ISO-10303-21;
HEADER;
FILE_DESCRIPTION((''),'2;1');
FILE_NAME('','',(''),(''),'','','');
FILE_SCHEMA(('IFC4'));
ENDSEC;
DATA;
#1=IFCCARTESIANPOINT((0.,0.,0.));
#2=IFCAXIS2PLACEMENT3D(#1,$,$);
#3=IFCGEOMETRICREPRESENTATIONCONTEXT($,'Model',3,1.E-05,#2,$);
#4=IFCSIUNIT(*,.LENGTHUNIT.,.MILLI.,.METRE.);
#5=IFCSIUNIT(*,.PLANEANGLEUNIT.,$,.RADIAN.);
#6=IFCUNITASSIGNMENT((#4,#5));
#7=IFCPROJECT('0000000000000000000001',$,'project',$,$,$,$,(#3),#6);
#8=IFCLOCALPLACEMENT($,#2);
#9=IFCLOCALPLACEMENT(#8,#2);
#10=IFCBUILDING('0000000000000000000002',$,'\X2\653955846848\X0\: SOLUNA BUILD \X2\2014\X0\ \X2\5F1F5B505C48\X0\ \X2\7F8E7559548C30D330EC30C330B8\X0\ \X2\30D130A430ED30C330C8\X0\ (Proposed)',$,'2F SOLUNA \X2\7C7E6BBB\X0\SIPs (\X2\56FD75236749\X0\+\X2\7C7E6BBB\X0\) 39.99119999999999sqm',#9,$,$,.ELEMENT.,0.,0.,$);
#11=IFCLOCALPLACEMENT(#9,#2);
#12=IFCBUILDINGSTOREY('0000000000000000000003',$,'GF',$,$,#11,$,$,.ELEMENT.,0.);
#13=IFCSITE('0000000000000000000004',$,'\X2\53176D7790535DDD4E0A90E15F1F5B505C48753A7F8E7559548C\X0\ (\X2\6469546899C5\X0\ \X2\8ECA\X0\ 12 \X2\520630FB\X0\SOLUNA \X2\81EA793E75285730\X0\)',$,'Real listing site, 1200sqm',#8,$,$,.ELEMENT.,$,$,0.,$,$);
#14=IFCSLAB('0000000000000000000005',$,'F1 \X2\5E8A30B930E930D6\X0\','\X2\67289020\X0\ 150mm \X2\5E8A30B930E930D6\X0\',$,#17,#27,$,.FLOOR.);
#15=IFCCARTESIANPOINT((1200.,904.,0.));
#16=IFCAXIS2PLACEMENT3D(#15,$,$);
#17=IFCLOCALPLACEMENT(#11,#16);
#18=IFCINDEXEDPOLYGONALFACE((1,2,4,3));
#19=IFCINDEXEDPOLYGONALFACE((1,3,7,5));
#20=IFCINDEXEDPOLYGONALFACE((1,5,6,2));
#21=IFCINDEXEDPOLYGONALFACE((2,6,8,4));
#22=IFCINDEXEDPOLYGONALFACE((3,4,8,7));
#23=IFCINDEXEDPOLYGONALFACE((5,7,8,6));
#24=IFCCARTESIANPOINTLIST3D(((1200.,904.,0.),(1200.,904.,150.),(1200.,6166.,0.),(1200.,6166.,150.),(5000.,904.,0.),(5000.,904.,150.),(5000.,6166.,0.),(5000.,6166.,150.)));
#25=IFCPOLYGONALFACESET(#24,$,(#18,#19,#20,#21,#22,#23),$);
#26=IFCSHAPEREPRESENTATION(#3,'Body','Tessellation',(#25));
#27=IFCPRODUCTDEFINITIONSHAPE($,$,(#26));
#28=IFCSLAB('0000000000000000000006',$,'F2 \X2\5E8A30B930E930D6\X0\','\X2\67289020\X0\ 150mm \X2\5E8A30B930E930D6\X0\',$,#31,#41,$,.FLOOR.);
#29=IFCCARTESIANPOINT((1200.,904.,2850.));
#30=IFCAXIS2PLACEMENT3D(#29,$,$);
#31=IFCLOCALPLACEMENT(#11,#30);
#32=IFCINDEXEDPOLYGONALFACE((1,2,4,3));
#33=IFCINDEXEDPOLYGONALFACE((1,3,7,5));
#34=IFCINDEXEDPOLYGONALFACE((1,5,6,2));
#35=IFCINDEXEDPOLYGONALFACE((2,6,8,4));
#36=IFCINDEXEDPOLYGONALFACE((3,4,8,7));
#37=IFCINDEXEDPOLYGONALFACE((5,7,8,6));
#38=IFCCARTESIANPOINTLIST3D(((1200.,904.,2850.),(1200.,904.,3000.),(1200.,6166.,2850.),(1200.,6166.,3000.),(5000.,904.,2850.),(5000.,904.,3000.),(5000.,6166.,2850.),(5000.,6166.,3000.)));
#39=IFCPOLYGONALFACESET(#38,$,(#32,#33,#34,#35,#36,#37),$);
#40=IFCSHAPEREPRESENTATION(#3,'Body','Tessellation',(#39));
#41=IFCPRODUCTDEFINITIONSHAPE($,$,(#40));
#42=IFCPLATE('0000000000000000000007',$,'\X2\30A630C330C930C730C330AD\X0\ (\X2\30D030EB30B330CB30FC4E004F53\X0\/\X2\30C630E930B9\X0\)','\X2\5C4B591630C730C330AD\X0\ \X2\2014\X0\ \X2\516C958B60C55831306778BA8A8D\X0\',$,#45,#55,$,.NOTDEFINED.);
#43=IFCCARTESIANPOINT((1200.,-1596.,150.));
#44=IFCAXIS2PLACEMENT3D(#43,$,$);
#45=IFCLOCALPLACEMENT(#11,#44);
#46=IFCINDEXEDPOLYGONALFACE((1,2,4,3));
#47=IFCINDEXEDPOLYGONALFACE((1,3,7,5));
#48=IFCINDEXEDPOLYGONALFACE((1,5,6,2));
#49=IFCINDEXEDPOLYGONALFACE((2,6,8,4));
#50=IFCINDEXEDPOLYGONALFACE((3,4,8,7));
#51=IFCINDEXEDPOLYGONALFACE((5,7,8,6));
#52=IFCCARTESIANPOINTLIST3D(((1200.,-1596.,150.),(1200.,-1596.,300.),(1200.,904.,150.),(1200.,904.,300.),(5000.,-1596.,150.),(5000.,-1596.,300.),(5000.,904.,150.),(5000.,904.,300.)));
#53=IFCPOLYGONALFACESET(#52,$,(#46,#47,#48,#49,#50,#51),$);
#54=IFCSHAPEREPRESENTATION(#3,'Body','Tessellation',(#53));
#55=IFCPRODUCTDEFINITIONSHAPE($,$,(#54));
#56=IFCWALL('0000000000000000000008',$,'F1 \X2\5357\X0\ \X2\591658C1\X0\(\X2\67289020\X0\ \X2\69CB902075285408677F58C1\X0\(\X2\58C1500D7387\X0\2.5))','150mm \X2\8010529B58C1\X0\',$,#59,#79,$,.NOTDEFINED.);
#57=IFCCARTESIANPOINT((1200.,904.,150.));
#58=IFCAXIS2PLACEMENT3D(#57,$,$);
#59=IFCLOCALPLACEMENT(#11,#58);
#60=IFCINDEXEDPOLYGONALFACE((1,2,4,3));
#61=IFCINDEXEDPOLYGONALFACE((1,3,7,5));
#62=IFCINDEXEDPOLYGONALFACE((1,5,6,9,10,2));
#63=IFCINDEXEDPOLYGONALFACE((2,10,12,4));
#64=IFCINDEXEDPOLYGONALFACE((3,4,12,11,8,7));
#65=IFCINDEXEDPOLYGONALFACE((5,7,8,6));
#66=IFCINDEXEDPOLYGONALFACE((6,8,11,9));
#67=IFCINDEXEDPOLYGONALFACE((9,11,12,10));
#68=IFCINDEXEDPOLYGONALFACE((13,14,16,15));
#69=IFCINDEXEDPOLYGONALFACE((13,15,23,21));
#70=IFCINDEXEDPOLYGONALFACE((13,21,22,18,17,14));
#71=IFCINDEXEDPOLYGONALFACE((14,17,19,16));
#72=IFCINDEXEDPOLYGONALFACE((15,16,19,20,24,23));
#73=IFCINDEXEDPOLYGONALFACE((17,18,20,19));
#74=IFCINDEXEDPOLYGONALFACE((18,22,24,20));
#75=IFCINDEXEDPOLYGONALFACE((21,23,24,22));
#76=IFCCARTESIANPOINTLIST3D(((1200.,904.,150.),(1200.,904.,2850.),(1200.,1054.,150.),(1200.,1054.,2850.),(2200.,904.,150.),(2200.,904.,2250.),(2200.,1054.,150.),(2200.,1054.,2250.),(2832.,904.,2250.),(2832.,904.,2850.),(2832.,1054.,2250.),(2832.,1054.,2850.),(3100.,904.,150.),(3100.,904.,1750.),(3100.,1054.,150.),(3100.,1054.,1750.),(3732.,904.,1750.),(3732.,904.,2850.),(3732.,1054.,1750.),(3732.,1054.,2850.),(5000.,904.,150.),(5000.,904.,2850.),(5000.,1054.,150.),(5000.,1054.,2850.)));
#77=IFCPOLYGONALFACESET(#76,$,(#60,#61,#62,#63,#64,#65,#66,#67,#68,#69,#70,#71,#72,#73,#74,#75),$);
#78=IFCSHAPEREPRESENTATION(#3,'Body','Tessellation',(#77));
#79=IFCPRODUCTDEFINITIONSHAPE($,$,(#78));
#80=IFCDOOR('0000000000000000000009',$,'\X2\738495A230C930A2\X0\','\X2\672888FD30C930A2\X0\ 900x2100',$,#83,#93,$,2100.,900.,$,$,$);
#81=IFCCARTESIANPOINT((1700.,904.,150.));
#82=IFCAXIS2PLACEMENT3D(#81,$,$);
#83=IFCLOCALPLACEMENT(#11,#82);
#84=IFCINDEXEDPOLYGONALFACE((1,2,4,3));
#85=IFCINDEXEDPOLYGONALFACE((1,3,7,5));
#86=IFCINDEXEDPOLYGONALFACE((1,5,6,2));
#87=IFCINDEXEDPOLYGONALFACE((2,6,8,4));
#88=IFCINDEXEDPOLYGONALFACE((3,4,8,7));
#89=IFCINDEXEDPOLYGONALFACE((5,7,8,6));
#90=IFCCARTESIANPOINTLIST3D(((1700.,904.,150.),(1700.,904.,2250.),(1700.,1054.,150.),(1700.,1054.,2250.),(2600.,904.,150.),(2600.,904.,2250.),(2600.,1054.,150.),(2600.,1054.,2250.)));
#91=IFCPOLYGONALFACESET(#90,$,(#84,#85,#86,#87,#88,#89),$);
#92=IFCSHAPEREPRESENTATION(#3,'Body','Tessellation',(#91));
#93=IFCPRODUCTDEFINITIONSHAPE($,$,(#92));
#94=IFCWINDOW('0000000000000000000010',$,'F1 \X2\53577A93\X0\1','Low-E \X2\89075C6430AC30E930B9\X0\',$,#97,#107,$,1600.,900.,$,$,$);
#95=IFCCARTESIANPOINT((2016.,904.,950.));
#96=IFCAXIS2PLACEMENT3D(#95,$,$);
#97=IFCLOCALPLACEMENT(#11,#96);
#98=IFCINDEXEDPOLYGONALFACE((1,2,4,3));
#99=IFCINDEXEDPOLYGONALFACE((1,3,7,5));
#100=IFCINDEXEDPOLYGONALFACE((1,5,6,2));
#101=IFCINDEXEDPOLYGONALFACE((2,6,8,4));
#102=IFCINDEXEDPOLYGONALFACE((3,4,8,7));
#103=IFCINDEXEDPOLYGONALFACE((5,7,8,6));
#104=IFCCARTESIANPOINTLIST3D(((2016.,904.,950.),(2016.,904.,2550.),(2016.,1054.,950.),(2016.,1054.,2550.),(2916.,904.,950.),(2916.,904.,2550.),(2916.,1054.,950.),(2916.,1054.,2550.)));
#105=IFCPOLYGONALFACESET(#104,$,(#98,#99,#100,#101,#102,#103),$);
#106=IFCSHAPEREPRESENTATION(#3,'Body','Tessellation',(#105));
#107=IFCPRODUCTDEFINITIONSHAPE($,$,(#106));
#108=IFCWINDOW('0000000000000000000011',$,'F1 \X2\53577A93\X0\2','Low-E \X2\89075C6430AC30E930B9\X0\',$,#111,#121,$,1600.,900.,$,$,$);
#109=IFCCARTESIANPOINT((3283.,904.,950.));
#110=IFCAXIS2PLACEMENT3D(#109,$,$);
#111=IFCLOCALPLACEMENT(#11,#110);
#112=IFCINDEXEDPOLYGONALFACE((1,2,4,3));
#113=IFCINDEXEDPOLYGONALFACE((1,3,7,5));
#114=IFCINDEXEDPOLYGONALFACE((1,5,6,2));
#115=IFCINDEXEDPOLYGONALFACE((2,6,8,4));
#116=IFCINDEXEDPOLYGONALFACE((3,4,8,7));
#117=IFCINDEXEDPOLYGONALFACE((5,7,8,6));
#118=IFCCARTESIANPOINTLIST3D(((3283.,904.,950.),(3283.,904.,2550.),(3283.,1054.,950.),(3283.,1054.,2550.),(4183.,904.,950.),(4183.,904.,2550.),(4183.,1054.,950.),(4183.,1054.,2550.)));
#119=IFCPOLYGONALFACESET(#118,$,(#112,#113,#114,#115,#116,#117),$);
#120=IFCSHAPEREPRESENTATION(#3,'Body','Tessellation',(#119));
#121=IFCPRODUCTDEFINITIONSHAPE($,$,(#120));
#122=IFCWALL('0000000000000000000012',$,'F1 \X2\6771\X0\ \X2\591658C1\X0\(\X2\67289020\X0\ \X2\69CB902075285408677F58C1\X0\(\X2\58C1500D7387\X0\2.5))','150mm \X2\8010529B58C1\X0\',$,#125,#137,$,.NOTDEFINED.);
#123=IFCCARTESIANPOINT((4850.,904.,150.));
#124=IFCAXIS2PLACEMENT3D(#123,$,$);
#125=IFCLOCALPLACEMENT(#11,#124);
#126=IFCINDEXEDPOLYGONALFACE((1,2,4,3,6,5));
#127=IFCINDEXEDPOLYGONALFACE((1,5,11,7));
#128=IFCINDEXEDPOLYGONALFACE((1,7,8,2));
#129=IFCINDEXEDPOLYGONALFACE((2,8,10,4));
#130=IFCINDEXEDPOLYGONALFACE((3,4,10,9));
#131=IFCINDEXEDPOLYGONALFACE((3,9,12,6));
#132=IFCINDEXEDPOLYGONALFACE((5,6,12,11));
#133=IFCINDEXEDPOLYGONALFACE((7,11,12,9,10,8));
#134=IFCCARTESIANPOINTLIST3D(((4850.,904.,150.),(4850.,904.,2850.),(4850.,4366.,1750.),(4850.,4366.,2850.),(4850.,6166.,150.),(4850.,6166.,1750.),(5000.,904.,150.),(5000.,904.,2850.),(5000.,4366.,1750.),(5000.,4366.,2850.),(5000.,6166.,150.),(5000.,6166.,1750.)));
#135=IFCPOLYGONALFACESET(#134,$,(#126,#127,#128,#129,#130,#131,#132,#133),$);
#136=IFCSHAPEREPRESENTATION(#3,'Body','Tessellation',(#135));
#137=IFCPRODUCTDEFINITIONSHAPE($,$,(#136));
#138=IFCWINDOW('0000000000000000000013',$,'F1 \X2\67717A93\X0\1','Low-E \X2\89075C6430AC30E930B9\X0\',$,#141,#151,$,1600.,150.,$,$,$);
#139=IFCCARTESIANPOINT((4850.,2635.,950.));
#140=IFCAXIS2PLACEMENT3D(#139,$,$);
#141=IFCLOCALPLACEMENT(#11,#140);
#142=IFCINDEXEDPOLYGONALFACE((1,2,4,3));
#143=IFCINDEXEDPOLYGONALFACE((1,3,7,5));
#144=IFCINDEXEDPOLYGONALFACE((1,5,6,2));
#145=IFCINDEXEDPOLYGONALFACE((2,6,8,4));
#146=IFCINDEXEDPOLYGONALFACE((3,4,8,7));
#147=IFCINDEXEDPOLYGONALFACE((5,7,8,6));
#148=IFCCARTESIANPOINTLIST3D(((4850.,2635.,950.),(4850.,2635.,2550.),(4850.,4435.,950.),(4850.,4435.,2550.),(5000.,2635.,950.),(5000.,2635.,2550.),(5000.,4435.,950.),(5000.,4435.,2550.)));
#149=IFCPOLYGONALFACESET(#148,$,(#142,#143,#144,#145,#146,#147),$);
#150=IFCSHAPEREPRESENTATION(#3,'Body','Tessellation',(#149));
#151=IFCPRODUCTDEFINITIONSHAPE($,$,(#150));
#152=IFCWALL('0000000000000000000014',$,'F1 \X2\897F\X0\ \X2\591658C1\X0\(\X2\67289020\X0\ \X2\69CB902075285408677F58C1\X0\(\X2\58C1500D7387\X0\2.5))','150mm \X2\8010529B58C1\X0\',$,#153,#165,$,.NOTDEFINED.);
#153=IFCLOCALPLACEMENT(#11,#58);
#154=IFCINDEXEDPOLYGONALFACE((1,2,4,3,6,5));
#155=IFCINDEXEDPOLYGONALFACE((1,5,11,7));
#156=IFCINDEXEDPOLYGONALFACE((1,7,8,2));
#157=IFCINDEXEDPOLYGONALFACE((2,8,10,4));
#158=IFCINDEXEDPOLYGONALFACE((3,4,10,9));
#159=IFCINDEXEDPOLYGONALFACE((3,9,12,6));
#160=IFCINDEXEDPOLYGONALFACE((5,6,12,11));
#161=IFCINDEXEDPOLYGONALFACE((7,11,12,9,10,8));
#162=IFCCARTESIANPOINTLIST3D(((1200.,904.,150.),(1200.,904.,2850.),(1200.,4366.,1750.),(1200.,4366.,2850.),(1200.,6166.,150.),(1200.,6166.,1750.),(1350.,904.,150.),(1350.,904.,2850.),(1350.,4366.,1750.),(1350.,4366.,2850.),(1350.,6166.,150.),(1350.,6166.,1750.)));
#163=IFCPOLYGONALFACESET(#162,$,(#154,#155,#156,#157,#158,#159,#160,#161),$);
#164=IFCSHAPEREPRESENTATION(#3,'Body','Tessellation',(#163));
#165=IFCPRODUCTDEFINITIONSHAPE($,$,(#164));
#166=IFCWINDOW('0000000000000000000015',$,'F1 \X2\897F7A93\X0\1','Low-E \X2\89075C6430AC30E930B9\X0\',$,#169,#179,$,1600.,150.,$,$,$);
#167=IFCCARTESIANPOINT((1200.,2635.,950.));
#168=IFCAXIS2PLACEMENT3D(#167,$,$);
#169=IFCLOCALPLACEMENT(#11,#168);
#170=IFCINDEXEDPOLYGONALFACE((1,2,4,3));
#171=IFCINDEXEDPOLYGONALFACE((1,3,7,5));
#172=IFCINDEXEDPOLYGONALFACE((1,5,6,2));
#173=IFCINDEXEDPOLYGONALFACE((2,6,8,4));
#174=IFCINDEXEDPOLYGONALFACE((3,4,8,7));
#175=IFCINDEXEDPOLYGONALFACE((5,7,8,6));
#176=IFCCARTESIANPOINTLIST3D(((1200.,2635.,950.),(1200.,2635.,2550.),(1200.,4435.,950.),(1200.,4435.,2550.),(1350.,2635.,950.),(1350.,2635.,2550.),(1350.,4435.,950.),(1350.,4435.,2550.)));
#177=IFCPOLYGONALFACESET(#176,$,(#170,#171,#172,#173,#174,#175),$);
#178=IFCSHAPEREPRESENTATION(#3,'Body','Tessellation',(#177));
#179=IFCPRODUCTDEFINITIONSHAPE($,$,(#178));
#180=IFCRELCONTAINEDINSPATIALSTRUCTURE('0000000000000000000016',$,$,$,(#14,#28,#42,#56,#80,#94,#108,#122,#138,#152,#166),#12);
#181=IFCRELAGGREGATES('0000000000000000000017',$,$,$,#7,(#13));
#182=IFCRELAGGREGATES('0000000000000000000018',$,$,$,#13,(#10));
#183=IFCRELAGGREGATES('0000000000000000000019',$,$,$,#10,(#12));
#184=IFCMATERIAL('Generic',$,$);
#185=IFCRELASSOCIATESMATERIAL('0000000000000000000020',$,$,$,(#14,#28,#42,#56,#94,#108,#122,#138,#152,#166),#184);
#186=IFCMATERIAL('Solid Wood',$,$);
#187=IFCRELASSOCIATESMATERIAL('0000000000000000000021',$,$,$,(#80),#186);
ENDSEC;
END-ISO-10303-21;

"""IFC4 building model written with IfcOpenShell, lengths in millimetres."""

from ifc_helpers import new_model, si_unit, frame, frame_2d, origin, place, context, project, spatial, rectangle, extrude, material, element, fill, save


model = new_model("IFC4")

# Units and contexts
model_context = context("Model", 3, precision=1e-05, world=origin())
ifc_project = project(units=[si_unit("LENGTHUNIT", "METRE", prefix="MILLI"), si_unit("PLANEANGLEUNIT", "RADIAN")], contexts=[model_context])

# Site, building, storey
site_placement = place(None, origin())
site = spatial("IfcSite", under=ifc_project, at=site_placement, Name="北海道川上郡弟子屈町美留和 (摩周駅 車 12 分・SOLUNA 自社用地)", ObjectType="Real listing site, 1200sqm", CompositionType="ELEMENT", RefElevation=0.0)
building_placement = place(site_placement, origin())
building = spatial("IfcBuilding", under=site, at=building_placement, Name="改善案: SOLUNA BUILD — 弟子屈 美留和ビレッジ パイロット (Proposed)", ObjectType="2F SOLUNA 籾殻SIPs (国産杉+籾殻) 39.99119999999999sqm", CompositionType="ELEMENT", ElevationOfRefHeight=0.0, ElevationOfTerrain=0.0)
storey_placement = place(building_placement, origin())
storey = spatial("IfcBuildingStorey", under=building, at=storey_placement, Name="GF", CompositionType="ELEMENT", Elevation=0.0)

# Slabs
ifc_material_1 = material(Name="Generic")
slab_1_placement = place(storey_placement, frame((1200.0, 904.0, 0.0)))
element("IfcSlab", 1, at=slab_1_placement, inside=storey, material=ifc_material_1, Name="F1 床スラブ", Description="木造 150mm 床スラブ", PredefinedType="FLOOR", context=model_context, shape_type="SweptSolid", body=[
    extrude(rectangle(XDim=3800.0, YDim=5262.0, at=frame_2d((1900.0, 2631.0))), frame((1200.0, 904.0, 0.0)), (0.0, 0.0, 1.0), 150.0),
])
slab_2_placement = place(storey_placement, frame((1200.0, 904.0, 2850.0)))
element("IfcSlab", 2, at=slab_2_placement, inside=storey, material=ifc_material_1, Name="F2 床スラブ", Description="木造 150mm 床スラブ", PredefinedType="FLOOR", context=model_context, shape_type="SweptSolid", body=[
    extrude(rectangle(XDim=3800.0, YDim=5262.0, at=frame_2d((1900.0, 2631.0))), frame((1200.0, 904.0, 2850.0)), (0.0, 0.0, 1.0), 150.0),
])

# Plate
plate_placement = place(storey_placement, frame((1200.0, -1596.0, 150.0)))
element("IfcPlate", 3, at=plate_placement, inside=storey, material=ifc_material_1, Name="ウッドデッキ (バルコニー一体/テラス)", Description="屋外デッキ — 公開情報で確認", PredefinedType="NOTDEFINED", context=model_context, shape_type="SweptSolid", body=[
    extrude(rectangle(XDim=3800.0, YDim=2500.0, at=frame_2d((1900.0, 1250.0))), frame((1200.0, -1596.0, 150.0)), (0.0, 0.0, 1.0), 150.0),
])

# Wall, openings, door, windows
wall_1_placement = place(storey_placement, frame((1200.0, 904.0, 150.0)))
wall_1 = element("IfcWall", 4, at=wall_1_placement, inside=storey, material=ifc_material_1, Name="F1 南 外壁(木造 構造用合板壁(壁倍率2.5))", Description="150mm 耐力壁", PredefinedType="NOTDEFINED", context=model_context, shape_type="SweptSolid", body=[
    extrude(rectangle(XDim=3800.0, YDim=150.0, at=frame_2d((1900.0, 75.0))), frame((1200.0, 904.0, 150.0)), (0.0, 0.0, 1.0), 2700.0),
])
opening_1_placement = place(storey_placement, frame((1700.0, 904.0, 150.0)))
opening_1 = element("IfcOpeningElement", 5, at=opening_1_placement, cuts=wall_1, PredefinedType="NOTDEFINED", context=model_context, shape_type="SweptSolid", body=[
    extrude(rectangle(XDim=900.0, YDim=150.0, at=frame_2d((450.0, 75.0))), frame((1700.0, 904.0, 150.0)), (0.0, 0.0, 1.0), 2100.0),
])
opening_2_placement = place(storey_placement, frame((2016.0, 904.0, 950.0)))
opening_2 = element("IfcOpeningElement", 6, at=opening_2_placement, cuts=wall_1, PredefinedType="NOTDEFINED", context=model_context, shape_type="SweptSolid", body=[
    extrude(rectangle(XDim=900.0, YDim=150.0, at=frame_2d((450.0, 75.0))), frame((2016.0, 904.0, 950.0)), (0.0, 0.0, 1.0), 1600.0),
])
opening_3_placement = place(storey_placement, frame((3283.0, 904.0, 950.0)))
opening_3 = element("IfcOpeningElement", 7, at=opening_3_placement, cuts=wall_1, PredefinedType="NOTDEFINED", context=model_context, shape_type="SweptSolid", body=[
    extrude(rectangle(XDim=900.0, YDim=150.0, at=frame_2d((450.0, 75.0))), frame((3283.0, 904.0, 950.0)), (0.0, 0.0, 1.0), 1600.0),
])
ifc_material_2 = material(Name="Solid Wood")
door_placement = place(storey_placement, frame((1700.0, 904.0, 150.0)))
door = element("IfcDoor", 8, at=door_placement, inside=storey, material=ifc_material_2, Name="玄関ドア", Description="木製ドア 900x2100", OverallHeight=2100.0, OverallWidth=900.0, context=model_context, shape_type="SweptSolid", body=[
    extrude(rectangle(XDim=900.0, YDim=150.0, at=frame_2d((450.0, 75.0))), frame((1700.0, 904.0, 150.0)), (0.0, 0.0, 1.0), 2100.0),
])
fill(opening_1, door)
window_1_placement = place(storey_placement, frame((2016.0, 904.0, 950.0)))
window_1 = element("IfcWindow", 9, at=window_1_placement, inside=storey, material=ifc_material_1, Name="F1 南窓1", Description="Low-E 複層ガラス", OverallHeight=1600.0, OverallWidth=900.0, context=model_context, shape_type="SweptSolid", body=[
    extrude(rectangle(XDim=900.0, YDim=150.0, at=frame_2d((450.0, 75.0))), frame((2016.0, 904.0, 950.0)), (0.0, 0.0, 1.0), 1600.0),
])
fill(opening_2, window_1)
window_2_placement = place(storey_placement, frame((3283.0, 904.0, 950.0)))
window_2 = element("IfcWindow", 10, at=window_2_placement, inside=storey, material=ifc_material_1, Name="F1 南窓2", Description="Low-E 複層ガラス", OverallHeight=1600.0, OverallWidth=900.0, context=model_context, shape_type="SweptSolid", body=[
    extrude(rectangle(XDim=900.0, YDim=150.0, at=frame_2d((450.0, 75.0))), frame((3283.0, 904.0, 950.0)), (0.0, 0.0, 1.0), 1600.0),
])
fill(opening_3, window_2)

# Walls, openings, windows
wall_2_placement = place(storey_placement, frame((4850.0, 904.0, 150.0)))
wall_2 = element("IfcWall", 11, at=wall_2_placement, inside=storey, material=ifc_material_1, Name="F1 東 外壁(木造 構造用合板壁(壁倍率2.5))", Description="150mm 耐力壁", PredefinedType="NOTDEFINED", context=model_context, shape_type="SweptSolid", body=[
    extrude(rectangle(XDim=150.0, YDim=5262.0, at=frame_2d((75.0, 2631.0))), frame((4850.0, 904.0, 150.0)), (0.0, 0.0, 1.0), 2700.0),
])
opening_4_placement = place(storey_placement, frame((4850.0, 2635.0, 950.0)))
opening_4 = element("IfcOpeningElement", 12, at=opening_4_placement, cuts=wall_2, PredefinedType="NOTDEFINED", context=model_context, shape_type="SweptSolid", body=[
    extrude(rectangle(XDim=150.0, YDim=1800.0, at=frame_2d((75.0, 900.0))), frame((4850.0, 2635.0, 950.0)), (0.0, 0.0, 1.0), 1600.0),
])
window_3_placement = place(storey_placement, frame((4850.0, 2635.0, 950.0)))
window_3 = element("IfcWindow", 13, at=window_3_placement, inside=storey, material=ifc_material_1, Name="F1 東窓1", Description="Low-E 複層ガラス", OverallHeight=1600.0, OverallWidth=150.0, context=model_context, shape_type="SweptSolid", body=[
    extrude(rectangle(XDim=150.0, YDim=1800.0, at=frame_2d((75.0, 900.0))), frame((4850.0, 2635.0, 950.0)), (0.0, 0.0, 1.0), 1600.0),
])
fill(opening_4, window_3)
wall_3_placement = place(storey_placement, frame((1200.0, 904.0, 150.0)))
wall_3 = element("IfcWall", 14, at=wall_3_placement, inside=storey, material=ifc_material_1, Name="F1 西 外壁(木造 構造用合板壁(壁倍率2.5))", Description="150mm 耐力壁", PredefinedType="NOTDEFINED", context=model_context, shape_type="SweptSolid", body=[
    extrude(rectangle(XDim=150.0, YDim=5262.0, at=frame_2d((75.0, 2631.0))), frame((1200.0, 904.0, 150.0)), (0.0, 0.0, 1.0), 2700.0),
])
opening_5_placement = place(storey_placement, frame((1200.0, 2635.0, 950.0)))
opening_5 = element("IfcOpeningElement", 15, at=opening_5_placement, cuts=wall_3, PredefinedType="NOTDEFINED", context=model_context, shape_type="SweptSolid", body=[
    extrude(rectangle(XDim=150.0, YDim=1800.0, at=frame_2d((75.0, 900.0))), frame((1200.0, 2635.0, 950.0)), (0.0, 0.0, 1.0), 1600.0),
])
window_4_placement = place(storey_placement, frame((1200.0, 2635.0, 950.0)))
window_4 = element("IfcWindow", 16, at=window_4_placement, inside=storey, material=ifc_material_1, Name="F1 西窓1", Description="Low-E 複層ガラス", OverallHeight=1600.0, OverallWidth=150.0, context=model_context, shape_type="SweptSolid", body=[
    extrude(rectangle(XDim=150.0, YDim=1800.0, at=frame_2d((75.0, 900.0))), frame((1200.0, 2635.0, 950.0)), (0.0, 0.0, 1.0), 1600.0),
])
fill(opening_5, window_4)

save(model, "model.ifc")
